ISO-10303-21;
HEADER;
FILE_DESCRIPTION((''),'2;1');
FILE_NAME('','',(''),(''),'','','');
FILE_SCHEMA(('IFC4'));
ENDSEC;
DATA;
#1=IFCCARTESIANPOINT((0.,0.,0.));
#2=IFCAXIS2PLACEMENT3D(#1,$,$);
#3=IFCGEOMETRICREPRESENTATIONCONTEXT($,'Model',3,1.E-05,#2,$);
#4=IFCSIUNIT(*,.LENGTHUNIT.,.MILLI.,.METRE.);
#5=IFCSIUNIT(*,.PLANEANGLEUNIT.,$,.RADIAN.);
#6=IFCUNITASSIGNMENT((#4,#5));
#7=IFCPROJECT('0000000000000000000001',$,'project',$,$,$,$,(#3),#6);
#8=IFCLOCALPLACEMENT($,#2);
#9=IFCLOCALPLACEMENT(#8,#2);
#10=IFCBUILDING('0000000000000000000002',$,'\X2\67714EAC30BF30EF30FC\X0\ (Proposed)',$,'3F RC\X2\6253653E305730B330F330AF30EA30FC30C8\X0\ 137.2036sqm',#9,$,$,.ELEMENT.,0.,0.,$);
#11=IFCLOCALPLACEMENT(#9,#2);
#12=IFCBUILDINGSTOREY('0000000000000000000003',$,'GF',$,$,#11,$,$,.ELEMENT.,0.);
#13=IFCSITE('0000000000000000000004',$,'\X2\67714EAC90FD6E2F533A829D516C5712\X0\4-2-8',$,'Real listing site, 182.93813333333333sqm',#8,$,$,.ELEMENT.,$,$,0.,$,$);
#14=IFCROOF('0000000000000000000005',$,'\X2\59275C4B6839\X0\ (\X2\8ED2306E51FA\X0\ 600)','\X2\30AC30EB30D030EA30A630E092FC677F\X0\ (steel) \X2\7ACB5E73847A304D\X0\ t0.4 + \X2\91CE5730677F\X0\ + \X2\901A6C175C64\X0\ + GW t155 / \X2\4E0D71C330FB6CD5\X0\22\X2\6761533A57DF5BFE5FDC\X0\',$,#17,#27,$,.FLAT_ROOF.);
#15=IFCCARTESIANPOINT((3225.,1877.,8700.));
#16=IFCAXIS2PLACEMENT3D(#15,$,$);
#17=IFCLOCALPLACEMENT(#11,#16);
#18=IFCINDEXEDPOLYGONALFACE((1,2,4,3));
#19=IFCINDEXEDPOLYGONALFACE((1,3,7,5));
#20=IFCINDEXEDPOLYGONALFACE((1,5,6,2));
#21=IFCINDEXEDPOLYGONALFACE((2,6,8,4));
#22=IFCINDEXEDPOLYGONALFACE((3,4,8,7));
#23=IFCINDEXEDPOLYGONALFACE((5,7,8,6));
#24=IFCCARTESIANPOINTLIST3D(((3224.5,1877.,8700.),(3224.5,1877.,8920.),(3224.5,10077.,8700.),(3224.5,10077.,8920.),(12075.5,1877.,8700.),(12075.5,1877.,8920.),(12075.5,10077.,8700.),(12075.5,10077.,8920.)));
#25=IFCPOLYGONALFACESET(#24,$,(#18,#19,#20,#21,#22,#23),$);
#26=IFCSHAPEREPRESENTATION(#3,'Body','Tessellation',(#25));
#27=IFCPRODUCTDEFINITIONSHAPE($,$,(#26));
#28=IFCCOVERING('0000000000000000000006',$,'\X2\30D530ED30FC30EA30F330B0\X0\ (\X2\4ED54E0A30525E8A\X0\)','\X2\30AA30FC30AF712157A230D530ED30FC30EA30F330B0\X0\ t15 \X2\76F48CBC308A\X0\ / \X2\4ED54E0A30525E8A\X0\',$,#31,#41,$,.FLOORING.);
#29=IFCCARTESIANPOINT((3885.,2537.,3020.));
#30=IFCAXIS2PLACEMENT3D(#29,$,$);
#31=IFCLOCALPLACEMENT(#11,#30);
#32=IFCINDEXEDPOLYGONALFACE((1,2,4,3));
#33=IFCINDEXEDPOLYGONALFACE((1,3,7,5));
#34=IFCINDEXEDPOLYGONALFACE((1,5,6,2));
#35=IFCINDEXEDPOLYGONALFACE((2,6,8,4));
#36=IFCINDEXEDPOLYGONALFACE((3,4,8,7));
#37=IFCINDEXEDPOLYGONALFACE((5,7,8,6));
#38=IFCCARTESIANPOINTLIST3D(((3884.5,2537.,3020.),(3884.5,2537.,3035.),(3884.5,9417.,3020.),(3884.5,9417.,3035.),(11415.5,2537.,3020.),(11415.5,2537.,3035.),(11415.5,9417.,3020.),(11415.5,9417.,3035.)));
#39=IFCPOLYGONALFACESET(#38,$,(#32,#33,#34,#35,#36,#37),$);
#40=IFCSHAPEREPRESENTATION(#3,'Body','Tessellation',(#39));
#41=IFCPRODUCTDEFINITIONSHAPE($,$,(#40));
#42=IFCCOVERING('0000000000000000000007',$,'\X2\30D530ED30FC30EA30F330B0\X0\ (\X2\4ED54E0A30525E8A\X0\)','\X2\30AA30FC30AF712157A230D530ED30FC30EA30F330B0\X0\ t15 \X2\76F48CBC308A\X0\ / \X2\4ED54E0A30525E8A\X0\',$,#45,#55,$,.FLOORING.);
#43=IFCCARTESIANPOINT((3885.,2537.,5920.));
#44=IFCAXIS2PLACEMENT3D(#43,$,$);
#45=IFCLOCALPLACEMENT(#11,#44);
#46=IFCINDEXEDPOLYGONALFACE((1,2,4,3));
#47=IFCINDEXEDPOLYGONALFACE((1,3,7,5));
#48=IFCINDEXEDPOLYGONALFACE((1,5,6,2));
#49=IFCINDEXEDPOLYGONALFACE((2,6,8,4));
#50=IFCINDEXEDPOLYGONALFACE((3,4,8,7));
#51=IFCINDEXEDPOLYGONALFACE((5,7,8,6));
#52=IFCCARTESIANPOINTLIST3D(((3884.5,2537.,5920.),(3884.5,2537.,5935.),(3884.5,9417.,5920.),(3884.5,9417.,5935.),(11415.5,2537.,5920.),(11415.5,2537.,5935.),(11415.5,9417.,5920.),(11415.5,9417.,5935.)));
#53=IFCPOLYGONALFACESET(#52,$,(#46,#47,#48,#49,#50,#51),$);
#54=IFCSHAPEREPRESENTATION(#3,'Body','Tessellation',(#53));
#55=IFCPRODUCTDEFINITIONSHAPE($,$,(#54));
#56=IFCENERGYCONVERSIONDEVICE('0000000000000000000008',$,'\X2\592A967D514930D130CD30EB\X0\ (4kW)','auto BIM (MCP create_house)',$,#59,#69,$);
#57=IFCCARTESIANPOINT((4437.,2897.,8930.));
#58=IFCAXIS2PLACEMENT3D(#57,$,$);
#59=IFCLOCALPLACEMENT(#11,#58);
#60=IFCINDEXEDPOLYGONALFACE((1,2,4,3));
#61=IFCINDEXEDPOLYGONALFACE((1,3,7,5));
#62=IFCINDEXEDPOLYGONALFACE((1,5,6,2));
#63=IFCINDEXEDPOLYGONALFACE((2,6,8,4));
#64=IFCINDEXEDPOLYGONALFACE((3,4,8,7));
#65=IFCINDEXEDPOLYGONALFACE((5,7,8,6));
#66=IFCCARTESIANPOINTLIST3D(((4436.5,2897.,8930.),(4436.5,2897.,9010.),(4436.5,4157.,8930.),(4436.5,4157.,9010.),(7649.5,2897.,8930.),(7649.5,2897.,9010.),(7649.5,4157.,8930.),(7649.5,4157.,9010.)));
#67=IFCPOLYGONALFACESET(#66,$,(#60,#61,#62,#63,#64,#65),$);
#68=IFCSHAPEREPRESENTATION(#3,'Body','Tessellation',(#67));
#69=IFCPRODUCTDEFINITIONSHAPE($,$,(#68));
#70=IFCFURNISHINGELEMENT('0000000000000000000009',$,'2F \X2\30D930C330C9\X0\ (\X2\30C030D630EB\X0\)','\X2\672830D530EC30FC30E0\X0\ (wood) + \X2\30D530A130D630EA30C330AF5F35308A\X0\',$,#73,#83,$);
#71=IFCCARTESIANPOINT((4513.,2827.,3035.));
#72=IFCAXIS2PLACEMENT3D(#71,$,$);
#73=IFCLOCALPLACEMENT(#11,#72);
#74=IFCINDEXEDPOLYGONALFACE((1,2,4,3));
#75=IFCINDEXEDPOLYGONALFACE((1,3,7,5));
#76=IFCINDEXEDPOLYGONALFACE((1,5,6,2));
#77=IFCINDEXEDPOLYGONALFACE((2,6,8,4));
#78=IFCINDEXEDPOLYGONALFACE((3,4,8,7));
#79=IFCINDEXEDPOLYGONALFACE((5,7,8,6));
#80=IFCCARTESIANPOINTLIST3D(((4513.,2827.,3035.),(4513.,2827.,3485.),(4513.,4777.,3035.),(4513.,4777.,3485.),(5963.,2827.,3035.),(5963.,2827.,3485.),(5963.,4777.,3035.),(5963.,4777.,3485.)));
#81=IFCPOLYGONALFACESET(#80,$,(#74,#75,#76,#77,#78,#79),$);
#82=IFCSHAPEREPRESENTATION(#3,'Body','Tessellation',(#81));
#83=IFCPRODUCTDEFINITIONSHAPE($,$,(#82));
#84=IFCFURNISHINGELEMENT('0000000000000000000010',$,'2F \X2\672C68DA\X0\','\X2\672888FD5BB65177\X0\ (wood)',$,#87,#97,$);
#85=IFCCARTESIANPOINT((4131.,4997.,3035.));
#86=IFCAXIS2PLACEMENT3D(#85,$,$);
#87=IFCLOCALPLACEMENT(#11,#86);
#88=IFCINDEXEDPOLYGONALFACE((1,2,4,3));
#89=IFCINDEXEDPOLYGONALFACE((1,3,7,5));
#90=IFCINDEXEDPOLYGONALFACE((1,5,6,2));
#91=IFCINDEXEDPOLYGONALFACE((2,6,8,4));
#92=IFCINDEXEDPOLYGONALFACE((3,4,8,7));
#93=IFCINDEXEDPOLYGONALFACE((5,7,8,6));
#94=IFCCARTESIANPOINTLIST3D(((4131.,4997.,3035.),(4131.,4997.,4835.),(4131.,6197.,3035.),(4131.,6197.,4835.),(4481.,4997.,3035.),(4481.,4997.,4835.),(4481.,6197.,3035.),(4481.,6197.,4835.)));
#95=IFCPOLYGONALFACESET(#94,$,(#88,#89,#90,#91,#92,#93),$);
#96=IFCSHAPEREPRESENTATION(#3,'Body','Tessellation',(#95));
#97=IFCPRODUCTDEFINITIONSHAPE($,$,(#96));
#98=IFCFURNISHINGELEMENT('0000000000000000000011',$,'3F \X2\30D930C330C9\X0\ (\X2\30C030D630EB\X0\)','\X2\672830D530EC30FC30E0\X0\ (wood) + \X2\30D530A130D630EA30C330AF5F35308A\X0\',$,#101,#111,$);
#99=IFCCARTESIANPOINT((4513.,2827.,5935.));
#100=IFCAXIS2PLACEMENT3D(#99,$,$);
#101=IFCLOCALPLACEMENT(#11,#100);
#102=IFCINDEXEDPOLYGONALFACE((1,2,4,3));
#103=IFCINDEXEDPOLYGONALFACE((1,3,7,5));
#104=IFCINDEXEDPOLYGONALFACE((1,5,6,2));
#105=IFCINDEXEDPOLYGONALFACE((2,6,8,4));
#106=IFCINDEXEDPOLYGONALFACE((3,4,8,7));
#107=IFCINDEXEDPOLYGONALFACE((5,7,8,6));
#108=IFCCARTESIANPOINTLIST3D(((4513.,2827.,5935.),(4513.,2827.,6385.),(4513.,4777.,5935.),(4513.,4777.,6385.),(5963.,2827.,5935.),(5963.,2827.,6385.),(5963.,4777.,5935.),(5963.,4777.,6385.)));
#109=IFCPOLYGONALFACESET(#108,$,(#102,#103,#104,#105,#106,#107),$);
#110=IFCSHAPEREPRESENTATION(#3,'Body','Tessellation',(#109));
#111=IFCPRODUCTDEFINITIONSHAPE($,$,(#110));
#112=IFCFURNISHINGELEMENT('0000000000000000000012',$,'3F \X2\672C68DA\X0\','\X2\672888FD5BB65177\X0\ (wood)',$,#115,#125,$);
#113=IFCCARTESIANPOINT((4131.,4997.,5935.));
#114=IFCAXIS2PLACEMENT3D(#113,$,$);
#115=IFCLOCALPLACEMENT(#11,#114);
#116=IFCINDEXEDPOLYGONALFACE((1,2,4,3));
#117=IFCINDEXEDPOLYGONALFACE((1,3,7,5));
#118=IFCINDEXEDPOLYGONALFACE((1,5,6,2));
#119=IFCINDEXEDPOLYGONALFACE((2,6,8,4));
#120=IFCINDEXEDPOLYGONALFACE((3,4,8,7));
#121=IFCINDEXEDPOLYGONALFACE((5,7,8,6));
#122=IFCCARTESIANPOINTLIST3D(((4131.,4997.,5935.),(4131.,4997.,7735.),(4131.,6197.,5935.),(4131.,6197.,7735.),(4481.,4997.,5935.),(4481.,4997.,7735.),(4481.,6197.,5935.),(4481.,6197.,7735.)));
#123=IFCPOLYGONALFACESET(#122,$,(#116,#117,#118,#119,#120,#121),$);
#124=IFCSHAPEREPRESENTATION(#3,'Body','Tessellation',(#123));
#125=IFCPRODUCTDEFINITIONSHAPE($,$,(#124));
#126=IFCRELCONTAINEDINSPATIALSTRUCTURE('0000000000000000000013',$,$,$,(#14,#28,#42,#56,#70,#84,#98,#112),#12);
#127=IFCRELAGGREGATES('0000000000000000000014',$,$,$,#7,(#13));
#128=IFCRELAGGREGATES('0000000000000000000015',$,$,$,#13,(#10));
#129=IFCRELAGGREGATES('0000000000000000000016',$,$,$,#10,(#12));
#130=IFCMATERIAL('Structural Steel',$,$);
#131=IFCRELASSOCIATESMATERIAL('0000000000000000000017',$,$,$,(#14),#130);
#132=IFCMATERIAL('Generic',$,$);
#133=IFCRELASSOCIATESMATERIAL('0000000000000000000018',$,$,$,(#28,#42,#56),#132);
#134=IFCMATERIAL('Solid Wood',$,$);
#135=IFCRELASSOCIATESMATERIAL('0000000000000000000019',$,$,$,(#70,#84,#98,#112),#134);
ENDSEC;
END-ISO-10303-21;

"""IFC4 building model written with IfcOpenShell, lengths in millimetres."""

from ifc_helpers import new_model, si_unit, frame, frame_2d, origin, place, context, project, spatial, rectangle, extrude, material, element, save


model = new_model("IFC4")

# Units and contexts
model_context = context("Model", 3, precision=1e-05, world=origin())
ifc_project = project(units=[si_unit("LENGTHUNIT", "METRE", prefix="MILLI"), si_unit("PLANEANGLEUNIT", "RADIAN")], contexts=[model_context])

# Site, building, storey
site_placement = place(None, origin())
site = spatial("IfcSite", under=ifc_project, at=site_placement, Name="東京都港区芝公園4-2-8", ObjectType="Real listing site, 182.93813333333333sqm", CompositionType="ELEMENT", RefElevation=0.0)
building_placement = place(site_placement, origin())
building = spatial("IfcBuilding", under=site, at=building_placement, Name="東京タワー (Proposed)", ObjectType="3F RC打放しコンクリート 137.2036sqm", CompositionType="ELEMENT", ElevationOfRefHeight=0.0, ElevationOfTerrain=0.0)
storey_placement = place(building_placement, origin())
storey = spatial("IfcBuildingStorey", under=building, at=storey_placement, Name="GF", CompositionType="ELEMENT", Elevation=0.0)

# Shared definitions
ifc_material_1 = material(Name="Solid Wood")

# Roof
ifc_material_2 = material(Name="Structural Steel")
roof_placement = place(storey_placement, frame((3225.0, 1877.0, 8700.0)))
element("IfcRoof", 1, at=roof_placement, inside=storey, material=ifc_material_2, Name="大屋根 (軒の出 600)", Description="ガルバリウム鋼板 (steel) 立平葺き t0.4 + 野地板 + 通気層 + GW t155 / 不燃・法22条区域対応", PredefinedType="FLAT_ROOF", context=model_context, shape_type="SweptSolid", body=[
    extrude(rectangle(XDim=8851.0, YDim=8200.0, at=frame_2d((4425.0, 4100.0))), frame((3225.0, 1877.0, 8700.0)), (0.0, 0.0, 1.0), 220.0),
])

# Coverings
ifc_material_3 = material(Name="Generic")
covering_1_placement = place(storey_placement, frame((3885.0, 2537.0, 3020.0)))
element("IfcCovering", 2, at=covering_1_placement, inside=storey, material=ifc_material_3, Name="フローリング (仕上げ床)", Description="オーク無垢フローリング t15 直貼り / 仕上げ床", PredefinedType="FLOORING", context=model_context, shape_type="SweptSolid", body=[
    extrude(rectangle(XDim=7531.0, YDim=6880.0, at=frame_2d((3765.0, 3440.0))), frame((3885.0, 2537.0, 3020.0)), (0.0, 0.0, 1.0), 15.0),
])
covering_2_placement = place(storey_placement, frame((3885.0, 2537.0, 5920.0)))
element("IfcCovering", 3, at=covering_2_placement, inside=storey, material=ifc_material_3, Name="フローリング (仕上げ床)", Description="オーク無垢フローリング t15 直貼り / 仕上げ床", PredefinedType="FLOORING", context=model_context, shape_type="SweptSolid", body=[
    extrude(rectangle(XDim=7531.0, YDim=6880.0, at=frame_2d((3765.0, 3440.0))), frame((3885.0, 2537.0, 5920.0)), (0.0, 0.0, 1.0), 15.0),
])

# Energy conversion device
energy_conversion_device_placement = place(storey_placement, frame((4437.0, 2897.0, 8930.0)))
element("IfcEnergyConversionDevice", 4, at=energy_conversion_device_placement, inside=storey, material=ifc_material_3, Name="太陽光パネル (4kW)", Description="auto BIM (MCP create_house)", context=model_context, shape_type="SweptSolid", body=[
    extrude(rectangle(XDim=3213.0, YDim=1260.0, at=frame_2d((1606.0, 630.0))), frame((4437.0, 2897.0, 8930.0)), (0.0, 0.0, 1.0), 80.0),
])

# Furnishing elements
furnishing_1_placement = place(storey_placement, frame((4513.0, 2827.0, 3035.0)))
element("IfcFurnishingElement", 5, at=furnishing_1_placement, inside=storey, material=ifc_material_1, Name="2F ベッド (ダブル)", Description="木フレーム (wood) + ファブリック張り", context=model_context, shape_type="SweptSolid", body=[
    extrude(rectangle(XDim=1450.0, YDim=1950.0, at=frame_2d((725.0, 975.0))), frame((4513.0, 2827.0, 3035.0)), (0.0, 0.0, 1.0), 450.0),
])
furnishing_2_placement = place(storey_placement, frame((4131.0, 4997.0, 3035.0)))
element("IfcFurnishingElement", 6, at=furnishing_2_placement, inside=storey, material=ifc_material_1, Name="2F 本棚", Description="木製家具 (wood)", context=model_context, shape_type="SweptSolid", body=[
    extrude(rectangle(XDim=350.0, YDim=1200.0, at=frame_2d((175.0, 600.0))), frame((4131.0, 4997.0, 3035.0)), (0.0, 0.0, 1.0), 1800.0),
])
furnishing_3_placement = place(storey_placement, frame((4513.0, 2827.0, 5935.0)))
element("IfcFurnishingElement", 7, at=furnishing_3_placement, inside=storey, material=ifc_material_1, Name="3F ベッド (ダブル)", Description="木フレーム (wood) + ファブリック張り", context=model_context, shape_type="SweptSolid", body=[
    extrude(rectangle(XDim=1450.0, YDim=1950.0, at=frame_2d((725.0, 975.0))), frame((4513.0, 2827.0, 5935.0)), (0.0, 0.0, 1.0), 450.0),
])
furnishing_4_placement = place(storey_placement, frame((4131.0, 4997.0, 5935.0)))
element("IfcFurnishingElement", 8, at=furnishing_4_placement, inside=storey, material=ifc_material_1, Name="3F 本棚", Description="木製家具 (wood)", context=model_context, shape_type="SweptSolid", body=[
    extrude(rectangle(XDim=350.0, YDim=1200.0, at=frame_2d((175.0, 600.0))), frame((4131.0, 4997.0, 5935.0)), (0.0, 0.0, 1.0), 1800.0),
])

save(model, "model.ifc")
